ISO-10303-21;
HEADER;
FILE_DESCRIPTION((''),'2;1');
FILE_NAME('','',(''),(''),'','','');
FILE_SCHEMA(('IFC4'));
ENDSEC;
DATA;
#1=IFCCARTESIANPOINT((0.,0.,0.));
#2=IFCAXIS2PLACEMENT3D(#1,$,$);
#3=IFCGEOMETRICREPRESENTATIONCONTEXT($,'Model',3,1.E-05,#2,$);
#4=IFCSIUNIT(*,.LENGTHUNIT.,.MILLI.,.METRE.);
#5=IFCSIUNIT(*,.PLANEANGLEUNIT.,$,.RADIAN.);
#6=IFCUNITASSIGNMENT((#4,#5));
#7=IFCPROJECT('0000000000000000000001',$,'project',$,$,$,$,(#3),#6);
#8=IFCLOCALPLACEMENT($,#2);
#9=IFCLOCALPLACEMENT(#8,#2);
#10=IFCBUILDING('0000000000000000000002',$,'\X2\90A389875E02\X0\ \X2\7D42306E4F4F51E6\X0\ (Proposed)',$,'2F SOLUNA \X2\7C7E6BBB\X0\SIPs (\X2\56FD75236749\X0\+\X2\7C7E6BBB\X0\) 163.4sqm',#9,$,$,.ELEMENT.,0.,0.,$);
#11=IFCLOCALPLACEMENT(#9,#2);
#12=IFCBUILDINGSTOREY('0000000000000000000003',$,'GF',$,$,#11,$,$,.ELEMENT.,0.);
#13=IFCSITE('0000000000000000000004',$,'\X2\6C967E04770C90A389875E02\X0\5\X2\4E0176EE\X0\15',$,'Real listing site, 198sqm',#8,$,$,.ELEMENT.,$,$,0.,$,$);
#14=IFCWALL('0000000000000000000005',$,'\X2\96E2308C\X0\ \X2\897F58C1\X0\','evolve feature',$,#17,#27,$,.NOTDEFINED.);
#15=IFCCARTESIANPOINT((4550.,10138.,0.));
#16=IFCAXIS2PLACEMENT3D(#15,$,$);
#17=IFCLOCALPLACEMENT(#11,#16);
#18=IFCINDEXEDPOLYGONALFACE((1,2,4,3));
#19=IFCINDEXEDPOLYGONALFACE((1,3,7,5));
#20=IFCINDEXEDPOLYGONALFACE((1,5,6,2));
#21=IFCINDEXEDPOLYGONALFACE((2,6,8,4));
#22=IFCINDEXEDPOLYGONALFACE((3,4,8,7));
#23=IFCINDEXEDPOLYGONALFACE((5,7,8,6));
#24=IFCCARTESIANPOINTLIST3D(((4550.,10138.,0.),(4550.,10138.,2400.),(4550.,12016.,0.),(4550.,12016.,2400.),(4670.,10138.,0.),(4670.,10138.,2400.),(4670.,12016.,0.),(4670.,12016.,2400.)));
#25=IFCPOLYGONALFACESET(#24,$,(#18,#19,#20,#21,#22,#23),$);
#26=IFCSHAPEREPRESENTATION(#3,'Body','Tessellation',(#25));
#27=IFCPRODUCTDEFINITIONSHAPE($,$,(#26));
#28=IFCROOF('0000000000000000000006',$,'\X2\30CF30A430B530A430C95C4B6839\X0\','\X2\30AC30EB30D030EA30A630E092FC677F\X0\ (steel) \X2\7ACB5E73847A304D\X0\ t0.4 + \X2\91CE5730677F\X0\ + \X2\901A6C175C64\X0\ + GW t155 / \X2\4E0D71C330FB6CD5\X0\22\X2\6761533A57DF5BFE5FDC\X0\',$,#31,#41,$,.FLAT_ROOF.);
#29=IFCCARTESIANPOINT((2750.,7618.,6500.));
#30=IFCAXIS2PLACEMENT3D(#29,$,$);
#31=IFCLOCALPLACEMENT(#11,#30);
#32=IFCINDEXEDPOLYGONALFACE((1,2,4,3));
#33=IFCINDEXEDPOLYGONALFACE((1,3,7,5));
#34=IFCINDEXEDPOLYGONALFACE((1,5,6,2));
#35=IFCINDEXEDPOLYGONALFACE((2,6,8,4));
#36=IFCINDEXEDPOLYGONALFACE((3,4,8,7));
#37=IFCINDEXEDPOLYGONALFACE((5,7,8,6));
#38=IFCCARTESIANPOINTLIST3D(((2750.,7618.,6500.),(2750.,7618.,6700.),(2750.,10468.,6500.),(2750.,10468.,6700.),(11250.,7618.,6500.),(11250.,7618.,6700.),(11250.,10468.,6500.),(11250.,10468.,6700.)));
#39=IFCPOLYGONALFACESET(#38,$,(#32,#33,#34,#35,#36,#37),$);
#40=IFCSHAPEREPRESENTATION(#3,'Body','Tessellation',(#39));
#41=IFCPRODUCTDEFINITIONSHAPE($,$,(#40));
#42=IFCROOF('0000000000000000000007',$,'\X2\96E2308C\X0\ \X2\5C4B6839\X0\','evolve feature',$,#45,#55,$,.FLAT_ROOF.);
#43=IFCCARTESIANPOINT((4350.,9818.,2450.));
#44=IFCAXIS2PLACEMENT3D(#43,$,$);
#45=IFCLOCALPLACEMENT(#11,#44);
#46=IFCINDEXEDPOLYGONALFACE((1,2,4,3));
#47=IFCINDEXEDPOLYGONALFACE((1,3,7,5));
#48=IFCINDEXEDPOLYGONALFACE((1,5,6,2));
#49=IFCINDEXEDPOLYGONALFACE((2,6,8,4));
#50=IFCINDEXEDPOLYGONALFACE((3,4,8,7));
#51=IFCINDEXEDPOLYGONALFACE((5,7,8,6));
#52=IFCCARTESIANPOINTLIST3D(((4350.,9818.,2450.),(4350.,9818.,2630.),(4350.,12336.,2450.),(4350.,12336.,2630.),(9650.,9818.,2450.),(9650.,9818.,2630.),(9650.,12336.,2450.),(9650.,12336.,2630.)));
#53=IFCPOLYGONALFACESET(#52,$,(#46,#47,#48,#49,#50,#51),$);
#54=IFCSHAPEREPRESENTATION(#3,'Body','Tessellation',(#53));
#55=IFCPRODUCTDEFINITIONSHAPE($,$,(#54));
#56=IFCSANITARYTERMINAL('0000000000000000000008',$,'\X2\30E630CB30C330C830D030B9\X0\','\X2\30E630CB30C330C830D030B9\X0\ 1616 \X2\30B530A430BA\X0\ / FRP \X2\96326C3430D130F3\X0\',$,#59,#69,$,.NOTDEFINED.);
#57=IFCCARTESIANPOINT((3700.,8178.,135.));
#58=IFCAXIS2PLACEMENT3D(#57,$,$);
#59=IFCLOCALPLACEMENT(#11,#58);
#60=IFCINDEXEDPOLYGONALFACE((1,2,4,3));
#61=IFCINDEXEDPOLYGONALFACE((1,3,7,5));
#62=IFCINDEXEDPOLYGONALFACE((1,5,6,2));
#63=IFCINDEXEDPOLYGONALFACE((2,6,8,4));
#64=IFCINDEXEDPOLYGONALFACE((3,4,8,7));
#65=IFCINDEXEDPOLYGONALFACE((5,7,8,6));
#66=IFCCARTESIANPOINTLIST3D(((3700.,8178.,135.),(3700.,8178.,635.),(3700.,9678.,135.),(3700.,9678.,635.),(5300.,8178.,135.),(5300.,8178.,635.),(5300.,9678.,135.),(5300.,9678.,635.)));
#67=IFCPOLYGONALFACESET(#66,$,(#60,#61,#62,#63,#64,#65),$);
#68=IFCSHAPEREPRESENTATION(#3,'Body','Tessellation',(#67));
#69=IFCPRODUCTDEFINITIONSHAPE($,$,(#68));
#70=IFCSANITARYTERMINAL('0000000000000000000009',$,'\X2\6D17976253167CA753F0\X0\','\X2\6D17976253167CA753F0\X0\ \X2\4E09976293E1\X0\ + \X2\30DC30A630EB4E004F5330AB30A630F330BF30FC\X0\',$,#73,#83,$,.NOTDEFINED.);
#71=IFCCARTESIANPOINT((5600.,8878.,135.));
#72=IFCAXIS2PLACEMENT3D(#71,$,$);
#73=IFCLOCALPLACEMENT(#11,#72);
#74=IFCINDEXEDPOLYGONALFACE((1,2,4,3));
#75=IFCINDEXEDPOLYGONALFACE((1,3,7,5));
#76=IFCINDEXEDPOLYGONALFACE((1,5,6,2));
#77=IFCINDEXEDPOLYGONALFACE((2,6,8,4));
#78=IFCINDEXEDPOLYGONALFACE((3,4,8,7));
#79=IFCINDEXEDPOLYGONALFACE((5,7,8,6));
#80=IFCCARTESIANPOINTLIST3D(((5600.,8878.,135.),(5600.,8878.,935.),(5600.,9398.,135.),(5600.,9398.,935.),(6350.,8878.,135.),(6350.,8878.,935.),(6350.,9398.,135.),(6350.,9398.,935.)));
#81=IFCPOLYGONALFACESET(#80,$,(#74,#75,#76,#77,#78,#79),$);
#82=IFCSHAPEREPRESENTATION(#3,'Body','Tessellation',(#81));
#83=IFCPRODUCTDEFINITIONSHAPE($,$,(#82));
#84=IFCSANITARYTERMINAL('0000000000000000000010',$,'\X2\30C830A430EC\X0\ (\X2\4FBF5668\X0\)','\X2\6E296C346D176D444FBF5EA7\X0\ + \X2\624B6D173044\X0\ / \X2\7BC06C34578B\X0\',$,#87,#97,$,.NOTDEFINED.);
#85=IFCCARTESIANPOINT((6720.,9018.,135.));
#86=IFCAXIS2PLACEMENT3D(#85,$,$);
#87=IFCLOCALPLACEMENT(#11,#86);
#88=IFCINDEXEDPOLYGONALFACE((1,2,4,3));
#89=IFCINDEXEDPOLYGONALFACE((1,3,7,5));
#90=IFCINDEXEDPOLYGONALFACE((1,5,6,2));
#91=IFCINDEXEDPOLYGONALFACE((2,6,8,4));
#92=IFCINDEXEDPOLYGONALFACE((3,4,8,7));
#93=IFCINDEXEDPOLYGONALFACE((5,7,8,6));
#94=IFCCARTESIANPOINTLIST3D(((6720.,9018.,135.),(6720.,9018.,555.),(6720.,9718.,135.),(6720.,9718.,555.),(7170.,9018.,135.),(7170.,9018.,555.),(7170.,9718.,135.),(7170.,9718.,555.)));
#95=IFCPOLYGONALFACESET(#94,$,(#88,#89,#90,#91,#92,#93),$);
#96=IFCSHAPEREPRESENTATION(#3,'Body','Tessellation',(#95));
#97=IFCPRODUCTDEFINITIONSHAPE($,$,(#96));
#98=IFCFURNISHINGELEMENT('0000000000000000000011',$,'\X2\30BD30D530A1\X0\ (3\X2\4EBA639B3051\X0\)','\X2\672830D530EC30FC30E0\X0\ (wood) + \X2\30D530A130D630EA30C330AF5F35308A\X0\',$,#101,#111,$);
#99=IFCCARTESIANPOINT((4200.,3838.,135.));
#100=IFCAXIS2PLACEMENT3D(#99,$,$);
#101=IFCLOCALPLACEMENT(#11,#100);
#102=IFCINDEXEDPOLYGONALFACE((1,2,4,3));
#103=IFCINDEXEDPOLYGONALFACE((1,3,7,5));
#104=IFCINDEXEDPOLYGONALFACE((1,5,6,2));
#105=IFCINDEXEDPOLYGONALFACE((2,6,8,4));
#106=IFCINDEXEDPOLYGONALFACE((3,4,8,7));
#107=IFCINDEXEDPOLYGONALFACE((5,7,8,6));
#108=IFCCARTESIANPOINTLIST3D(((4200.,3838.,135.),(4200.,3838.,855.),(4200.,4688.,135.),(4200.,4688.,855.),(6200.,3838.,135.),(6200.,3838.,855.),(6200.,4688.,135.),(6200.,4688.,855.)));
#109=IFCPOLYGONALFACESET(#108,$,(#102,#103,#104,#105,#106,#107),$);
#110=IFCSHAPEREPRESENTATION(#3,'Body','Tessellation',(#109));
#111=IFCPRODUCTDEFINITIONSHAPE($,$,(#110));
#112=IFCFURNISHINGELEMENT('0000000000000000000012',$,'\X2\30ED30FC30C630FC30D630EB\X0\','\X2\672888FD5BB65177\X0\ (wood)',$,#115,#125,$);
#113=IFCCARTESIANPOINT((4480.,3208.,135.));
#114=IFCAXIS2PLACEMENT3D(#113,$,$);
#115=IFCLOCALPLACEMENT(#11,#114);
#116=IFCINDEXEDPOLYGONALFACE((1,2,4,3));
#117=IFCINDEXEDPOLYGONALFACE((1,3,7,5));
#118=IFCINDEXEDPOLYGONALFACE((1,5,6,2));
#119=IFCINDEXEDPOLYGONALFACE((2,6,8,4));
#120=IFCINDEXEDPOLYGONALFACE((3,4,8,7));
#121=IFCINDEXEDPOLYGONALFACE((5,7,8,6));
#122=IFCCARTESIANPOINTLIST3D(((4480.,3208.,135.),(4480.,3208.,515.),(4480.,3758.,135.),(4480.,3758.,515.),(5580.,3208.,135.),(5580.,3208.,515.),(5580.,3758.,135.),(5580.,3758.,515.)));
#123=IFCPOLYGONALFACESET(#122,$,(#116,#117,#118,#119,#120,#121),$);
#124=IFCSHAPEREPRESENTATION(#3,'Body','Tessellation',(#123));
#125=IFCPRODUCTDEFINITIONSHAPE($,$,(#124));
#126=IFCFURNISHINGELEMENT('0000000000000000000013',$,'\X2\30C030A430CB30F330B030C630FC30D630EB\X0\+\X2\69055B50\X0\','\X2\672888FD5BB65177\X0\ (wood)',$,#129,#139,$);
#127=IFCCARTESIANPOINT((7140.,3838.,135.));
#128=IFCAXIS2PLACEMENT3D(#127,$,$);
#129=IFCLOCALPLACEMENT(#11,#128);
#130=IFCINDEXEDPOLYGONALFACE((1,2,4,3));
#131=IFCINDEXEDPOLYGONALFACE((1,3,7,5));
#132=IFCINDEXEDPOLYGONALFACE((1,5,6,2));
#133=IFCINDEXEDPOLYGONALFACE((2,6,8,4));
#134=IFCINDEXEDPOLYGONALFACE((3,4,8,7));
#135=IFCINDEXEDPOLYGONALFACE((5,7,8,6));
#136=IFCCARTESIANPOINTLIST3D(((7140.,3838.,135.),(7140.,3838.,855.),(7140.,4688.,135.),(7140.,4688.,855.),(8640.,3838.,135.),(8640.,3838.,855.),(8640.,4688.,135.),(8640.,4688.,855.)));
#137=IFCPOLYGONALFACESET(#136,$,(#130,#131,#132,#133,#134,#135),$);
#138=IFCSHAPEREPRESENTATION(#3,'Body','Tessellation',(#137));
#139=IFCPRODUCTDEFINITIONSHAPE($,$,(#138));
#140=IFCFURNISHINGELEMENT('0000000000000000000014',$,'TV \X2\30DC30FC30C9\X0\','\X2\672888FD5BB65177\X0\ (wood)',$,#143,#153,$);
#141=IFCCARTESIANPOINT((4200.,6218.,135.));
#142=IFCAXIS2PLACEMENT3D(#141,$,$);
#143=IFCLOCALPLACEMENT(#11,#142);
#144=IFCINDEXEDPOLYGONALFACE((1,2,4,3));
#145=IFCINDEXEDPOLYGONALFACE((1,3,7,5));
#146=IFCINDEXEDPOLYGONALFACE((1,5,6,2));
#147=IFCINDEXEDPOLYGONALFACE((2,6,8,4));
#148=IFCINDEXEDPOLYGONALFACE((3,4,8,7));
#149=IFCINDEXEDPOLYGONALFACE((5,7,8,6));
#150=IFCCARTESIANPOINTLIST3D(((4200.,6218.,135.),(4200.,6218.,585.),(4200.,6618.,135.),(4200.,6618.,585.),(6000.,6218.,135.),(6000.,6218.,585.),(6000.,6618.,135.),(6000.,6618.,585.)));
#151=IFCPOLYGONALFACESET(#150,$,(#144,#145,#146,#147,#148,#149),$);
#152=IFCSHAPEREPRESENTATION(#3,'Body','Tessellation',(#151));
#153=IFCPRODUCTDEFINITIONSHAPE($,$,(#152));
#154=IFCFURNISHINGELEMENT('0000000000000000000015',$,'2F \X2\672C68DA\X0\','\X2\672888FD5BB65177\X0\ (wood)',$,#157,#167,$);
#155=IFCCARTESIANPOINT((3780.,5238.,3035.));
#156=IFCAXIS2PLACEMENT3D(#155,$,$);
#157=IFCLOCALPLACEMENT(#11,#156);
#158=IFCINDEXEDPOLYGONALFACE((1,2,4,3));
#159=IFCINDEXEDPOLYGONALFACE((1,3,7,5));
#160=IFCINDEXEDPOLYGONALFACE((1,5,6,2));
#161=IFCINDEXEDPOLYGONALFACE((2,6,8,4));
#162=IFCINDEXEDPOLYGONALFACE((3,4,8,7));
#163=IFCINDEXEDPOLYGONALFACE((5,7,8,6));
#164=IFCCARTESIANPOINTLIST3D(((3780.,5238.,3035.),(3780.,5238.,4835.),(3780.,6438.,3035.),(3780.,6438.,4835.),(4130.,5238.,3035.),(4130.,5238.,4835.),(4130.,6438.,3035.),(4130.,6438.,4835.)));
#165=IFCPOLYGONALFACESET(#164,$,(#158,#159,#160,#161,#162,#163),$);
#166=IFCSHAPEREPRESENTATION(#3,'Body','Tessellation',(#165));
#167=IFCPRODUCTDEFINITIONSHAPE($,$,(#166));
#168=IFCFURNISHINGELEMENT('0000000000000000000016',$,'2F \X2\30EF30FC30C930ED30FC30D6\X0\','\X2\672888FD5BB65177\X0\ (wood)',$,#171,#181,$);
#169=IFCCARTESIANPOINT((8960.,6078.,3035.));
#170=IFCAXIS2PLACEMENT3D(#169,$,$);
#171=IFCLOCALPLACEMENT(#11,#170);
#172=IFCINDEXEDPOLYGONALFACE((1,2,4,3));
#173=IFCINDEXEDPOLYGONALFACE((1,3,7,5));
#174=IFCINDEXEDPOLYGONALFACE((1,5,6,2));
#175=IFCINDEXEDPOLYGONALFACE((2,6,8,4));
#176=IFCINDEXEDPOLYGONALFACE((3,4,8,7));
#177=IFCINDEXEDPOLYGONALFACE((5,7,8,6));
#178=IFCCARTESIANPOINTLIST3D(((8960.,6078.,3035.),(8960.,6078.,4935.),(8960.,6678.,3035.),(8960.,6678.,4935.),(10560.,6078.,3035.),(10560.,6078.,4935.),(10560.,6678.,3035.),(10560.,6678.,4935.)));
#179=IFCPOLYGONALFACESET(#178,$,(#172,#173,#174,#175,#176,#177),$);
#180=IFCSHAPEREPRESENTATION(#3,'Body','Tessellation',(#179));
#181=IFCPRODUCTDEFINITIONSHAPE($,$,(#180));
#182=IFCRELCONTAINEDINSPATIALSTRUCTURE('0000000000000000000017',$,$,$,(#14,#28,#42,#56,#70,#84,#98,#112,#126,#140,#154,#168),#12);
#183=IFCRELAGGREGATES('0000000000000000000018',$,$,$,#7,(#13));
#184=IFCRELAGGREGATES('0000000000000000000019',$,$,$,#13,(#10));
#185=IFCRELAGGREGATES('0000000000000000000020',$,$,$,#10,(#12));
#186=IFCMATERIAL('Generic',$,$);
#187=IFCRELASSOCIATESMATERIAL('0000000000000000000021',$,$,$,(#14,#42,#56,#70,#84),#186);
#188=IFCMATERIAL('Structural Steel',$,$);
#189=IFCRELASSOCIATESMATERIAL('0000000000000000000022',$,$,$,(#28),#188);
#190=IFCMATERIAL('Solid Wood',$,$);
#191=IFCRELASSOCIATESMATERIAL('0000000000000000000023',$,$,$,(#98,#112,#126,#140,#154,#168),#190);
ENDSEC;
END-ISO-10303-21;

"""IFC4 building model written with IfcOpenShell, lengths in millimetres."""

from ifc_helpers import new_model, si_unit, frame, frame_2d, origin, place, context, project, spatial, rectangle, extrude, material, element, save


model = new_model("IFC4")

# Units and contexts
model_context = context("Model", 3, precision=1e-05, world=origin())
ifc_project = project(units=[si_unit("LENGTHUNIT", "METRE", prefix="MILLI"), si_unit("PLANEANGLEUNIT", "RADIAN")], contexts=[model_context])

# Site, building, storey
site_placement = place(None, origin())
site = spatial("IfcSite", under=ifc_project, at=site_placement, Name="沖縄県那覇市5丁目15", ObjectType="Real listing site, 198sqm", CompositionType="ELEMENT", RefElevation=0.0)
building_placement = place(site_placement, origin())
building = spatial("IfcBuilding", under=site, at=building_placement, Name="那覇市 終の住処 (Proposed)", ObjectType="2F SOLUNA 籾殻SIPs (国産杉+籾殻) 163.4sqm", CompositionType="ELEMENT", ElevationOfRefHeight=0.0, ElevationOfTerrain=0.0)
storey_placement = place(building_placement, origin())
storey = spatial("IfcBuildingStorey", under=building, at=storey_placement, Name="GF", CompositionType="ELEMENT", Elevation=0.0)

# Shared definitions
ifc_material_1 = material(Name="Generic")

# Shared definitions
ifc_material_2 = material(Name="Solid Wood")

# Wall
wall_1_placement = place(storey_placement, frame((4550.0, 10138.0, 0.0)))
element("IfcWall", 1, at=wall_1_placement, inside=storey, material=ifc_material_1, Name="離れ 西壁", Description="evolve feature", PredefinedType="NOTDEFINED", context=model_context, shape_type="SweptSolid", body=[
    extrude(rectangle(XDim=120.0, YDim=1878.0, at=frame_2d((60.0, 939.0))), frame((4550.0, 10138.0, 0.0)), (0.0, 0.0, 1.0), 2400.0),
])

# Roofs
ifc_material_3 = material(Name="Structural Steel")
roof_1_placement = place(storey_placement, frame((2750.0, 7618.0, 6500.0)))
element("IfcRoof", 2, at=roof_1_placement, inside=storey, material=ifc_material_3, Name="ハイサイド屋根", Description="ガルバリウム鋼板 (steel) 立平葺き t0.4 + 野地板 + 通気層 + GW t155 / 不燃・法22条区域対応", PredefinedType="FLAT_ROOF", context=model_context, shape_type="SweptSolid", body=[
    extrude(rectangle(XDim=8500.0, YDim=2850.0, at=frame_2d((4250.0, 1425.0))), frame((2750.0, 7618.0, 6500.0)), (0.0, 0.0, 1.0), 200.0),
])
roof_2_placement = place(storey_placement, frame((4350.0, 9818.0, 2450.0)))
element("IfcRoof", 3, at=roof_2_placement, inside=storey, material=ifc_material_1, Name="離れ 屋根", Description="evolve feature", PredefinedType="FLAT_ROOF", context=model_context, shape_type="SweptSolid", body=[
    extrude(rectangle(XDim=5300.0, YDim=2518.0, at=frame_2d((2650.0, 1259.0))), frame((4350.0, 9818.0, 2450.0)), (0.0, 0.0, 1.0), 180.0),
])

# Sanitary terminals
sanitary_terminal_1_placement = place(storey_placement, frame((3700.0, 8178.0, 135.0)))
element("IfcSanitaryTerminal", 4, at=sanitary_terminal_1_placement, inside=storey, material=ifc_material_1, Name="ユニットバス", Description="ユニットバス 1616 サイズ / FRP 防水パン", PredefinedType="NOTDEFINED", context=model_context, shape_type="SweptSolid", body=[
    extrude(rectangle(XDim=1600.0, YDim=1500.0, at=frame_2d((800.0, 750.0))), frame((3700.0, 8178.0, 135.0)), (0.0, 0.0, 1.0), 500.0),
])
sanitary_terminal_2_placement = place(storey_placement, frame((5600.0, 8878.0, 135.0)))
element("IfcSanitaryTerminal", 5, at=sanitary_terminal_2_placement, inside=storey, material=ifc_material_1, Name="洗面化粧台", Description="洗面化粧台 三面鏡 + ボウル一体カウンター", PredefinedType="NOTDEFINED", context=model_context, shape_type="SweptSolid", body=[
    extrude(rectangle(XDim=750.0, YDim=520.0, at=frame_2d((375.0, 260.0))), frame((5600.0, 8878.0, 135.0)), (0.0, 0.0, 1.0), 800.0),
])
sanitary_terminal_3_placement = place(storey_placement, frame((6720.0, 9018.0, 135.0)))
element("IfcSanitaryTerminal", 6, at=sanitary_terminal_3_placement, inside=storey, material=ifc_material_1, Name="トイレ (便器)", Description="温水洗浄便座 + 手洗い / 節水型", PredefinedType="NOTDEFINED", context=model_context, shape_type="SweptSolid", body=[
    extrude(rectangle(XDim=450.0, YDim=700.0, at=frame_2d((225.0, 350.0))), frame((6720.0, 9018.0, 135.0)), (0.0, 0.0, 1.0), 420.0),
])

# Furnishing elements
furnishing_1_placement = place(storey_placement, frame((4200.0, 3838.0, 135.0)))
element("IfcFurnishingElement", 7, at=furnishing_1_placement, inside=storey, material=ifc_material_2, Name="ソファ (3人掛け)", Description="木フレーム (wood) + ファブリック張り", context=model_context, shape_type="SweptSolid", body=[
    extrude(rectangle(XDim=2000.0, YDim=850.0, at=frame_2d((1000.0, 425.0))), frame((4200.0, 3838.0, 135.0)), (0.0, 0.0, 1.0), 720.0),
])
furnishing_2_placement = place(storey_placement, frame((4480.0, 3208.0, 135.0)))
element("IfcFurnishingElement", 8, at=furnishing_2_placement, inside=storey, material=ifc_material_2, Name="ローテーブル", Description="木製家具 (wood)", context=model_context, shape_type="SweptSolid", body=[
    extrude(rectangle(XDim=1100.0, YDim=550.0, at=frame_2d((550.0, 275.0))), frame((4480.0, 3208.0, 135.0)), (0.0, 0.0, 1.0), 380.0),
])
furnishing_3_placement = place(storey_placement, frame((7140.0, 3838.0, 135.0)))
element("IfcFurnishingElement", 9, at=furnishing_3_placement, inside=storey, material=ifc_material_2, Name="ダイニングテーブル+椅子", Description="木製家具 (wood)", context=model_context, shape_type="SweptSolid", body=[
    extrude(rectangle(XDim=1500.0, YDim=850.0, at=frame_2d((750.0, 425.0))), frame((7140.0, 3838.0, 135.0)), (0.0, 0.0, 1.0), 720.0),
])
furnishing_4_placement = place(storey_placement, frame((4200.0, 6218.0, 135.0)))
element("IfcFurnishingElement", 10, at=furnishing_4_placement, inside=storey, material=ifc_material_2, Name="TV ボード", Description="木製家具 (wood)", context=model_context, shape_type="SweptSolid", body=[
    extrude(rectangle(XDim=1800.0, YDim=400.0, at=frame_2d((900.0, 200.0))), frame((4200.0, 6218.0, 135.0)), (0.0, 0.0, 1.0), 450.0),
])
furnishing_5_placement = place(storey_placement, frame((3780.0, 5238.0, 3035.0)))
element("IfcFurnishingElement", 11, at=furnishing_5_placement, inside=storey, material=ifc_material_2, Name="2F 本棚", Description="木製家具 (wood)", context=model_context, shape_type="SweptSolid", body=[
    extrude(rectangle(XDim=350.0, YDim=1200.0, at=frame_2d((175.0, 600.0))), frame((3780.0, 5238.0, 3035.0)), (0.0, 0.0, 1.0), 1800.0),
])
furnishing_6_placement = place(storey_placement, frame((8960.0, 6078.0, 3035.0)))
element("IfcFurnishingElement", 12, at=furnishing_6_placement, inside=storey, material=ifc_material_2, Name="2F ワードローブ", Description="木製家具 (wood)", context=model_context, shape_type="SweptSolid", body=[
    extrude(rectangle(XDim=1600.0, YDim=600.0, at=frame_2d((800.0, 300.0))), frame((8960.0, 6078.0, 3035.0)), (0.0, 0.0, 1.0), 1900.0),
])

save(model, "model.ifc")
